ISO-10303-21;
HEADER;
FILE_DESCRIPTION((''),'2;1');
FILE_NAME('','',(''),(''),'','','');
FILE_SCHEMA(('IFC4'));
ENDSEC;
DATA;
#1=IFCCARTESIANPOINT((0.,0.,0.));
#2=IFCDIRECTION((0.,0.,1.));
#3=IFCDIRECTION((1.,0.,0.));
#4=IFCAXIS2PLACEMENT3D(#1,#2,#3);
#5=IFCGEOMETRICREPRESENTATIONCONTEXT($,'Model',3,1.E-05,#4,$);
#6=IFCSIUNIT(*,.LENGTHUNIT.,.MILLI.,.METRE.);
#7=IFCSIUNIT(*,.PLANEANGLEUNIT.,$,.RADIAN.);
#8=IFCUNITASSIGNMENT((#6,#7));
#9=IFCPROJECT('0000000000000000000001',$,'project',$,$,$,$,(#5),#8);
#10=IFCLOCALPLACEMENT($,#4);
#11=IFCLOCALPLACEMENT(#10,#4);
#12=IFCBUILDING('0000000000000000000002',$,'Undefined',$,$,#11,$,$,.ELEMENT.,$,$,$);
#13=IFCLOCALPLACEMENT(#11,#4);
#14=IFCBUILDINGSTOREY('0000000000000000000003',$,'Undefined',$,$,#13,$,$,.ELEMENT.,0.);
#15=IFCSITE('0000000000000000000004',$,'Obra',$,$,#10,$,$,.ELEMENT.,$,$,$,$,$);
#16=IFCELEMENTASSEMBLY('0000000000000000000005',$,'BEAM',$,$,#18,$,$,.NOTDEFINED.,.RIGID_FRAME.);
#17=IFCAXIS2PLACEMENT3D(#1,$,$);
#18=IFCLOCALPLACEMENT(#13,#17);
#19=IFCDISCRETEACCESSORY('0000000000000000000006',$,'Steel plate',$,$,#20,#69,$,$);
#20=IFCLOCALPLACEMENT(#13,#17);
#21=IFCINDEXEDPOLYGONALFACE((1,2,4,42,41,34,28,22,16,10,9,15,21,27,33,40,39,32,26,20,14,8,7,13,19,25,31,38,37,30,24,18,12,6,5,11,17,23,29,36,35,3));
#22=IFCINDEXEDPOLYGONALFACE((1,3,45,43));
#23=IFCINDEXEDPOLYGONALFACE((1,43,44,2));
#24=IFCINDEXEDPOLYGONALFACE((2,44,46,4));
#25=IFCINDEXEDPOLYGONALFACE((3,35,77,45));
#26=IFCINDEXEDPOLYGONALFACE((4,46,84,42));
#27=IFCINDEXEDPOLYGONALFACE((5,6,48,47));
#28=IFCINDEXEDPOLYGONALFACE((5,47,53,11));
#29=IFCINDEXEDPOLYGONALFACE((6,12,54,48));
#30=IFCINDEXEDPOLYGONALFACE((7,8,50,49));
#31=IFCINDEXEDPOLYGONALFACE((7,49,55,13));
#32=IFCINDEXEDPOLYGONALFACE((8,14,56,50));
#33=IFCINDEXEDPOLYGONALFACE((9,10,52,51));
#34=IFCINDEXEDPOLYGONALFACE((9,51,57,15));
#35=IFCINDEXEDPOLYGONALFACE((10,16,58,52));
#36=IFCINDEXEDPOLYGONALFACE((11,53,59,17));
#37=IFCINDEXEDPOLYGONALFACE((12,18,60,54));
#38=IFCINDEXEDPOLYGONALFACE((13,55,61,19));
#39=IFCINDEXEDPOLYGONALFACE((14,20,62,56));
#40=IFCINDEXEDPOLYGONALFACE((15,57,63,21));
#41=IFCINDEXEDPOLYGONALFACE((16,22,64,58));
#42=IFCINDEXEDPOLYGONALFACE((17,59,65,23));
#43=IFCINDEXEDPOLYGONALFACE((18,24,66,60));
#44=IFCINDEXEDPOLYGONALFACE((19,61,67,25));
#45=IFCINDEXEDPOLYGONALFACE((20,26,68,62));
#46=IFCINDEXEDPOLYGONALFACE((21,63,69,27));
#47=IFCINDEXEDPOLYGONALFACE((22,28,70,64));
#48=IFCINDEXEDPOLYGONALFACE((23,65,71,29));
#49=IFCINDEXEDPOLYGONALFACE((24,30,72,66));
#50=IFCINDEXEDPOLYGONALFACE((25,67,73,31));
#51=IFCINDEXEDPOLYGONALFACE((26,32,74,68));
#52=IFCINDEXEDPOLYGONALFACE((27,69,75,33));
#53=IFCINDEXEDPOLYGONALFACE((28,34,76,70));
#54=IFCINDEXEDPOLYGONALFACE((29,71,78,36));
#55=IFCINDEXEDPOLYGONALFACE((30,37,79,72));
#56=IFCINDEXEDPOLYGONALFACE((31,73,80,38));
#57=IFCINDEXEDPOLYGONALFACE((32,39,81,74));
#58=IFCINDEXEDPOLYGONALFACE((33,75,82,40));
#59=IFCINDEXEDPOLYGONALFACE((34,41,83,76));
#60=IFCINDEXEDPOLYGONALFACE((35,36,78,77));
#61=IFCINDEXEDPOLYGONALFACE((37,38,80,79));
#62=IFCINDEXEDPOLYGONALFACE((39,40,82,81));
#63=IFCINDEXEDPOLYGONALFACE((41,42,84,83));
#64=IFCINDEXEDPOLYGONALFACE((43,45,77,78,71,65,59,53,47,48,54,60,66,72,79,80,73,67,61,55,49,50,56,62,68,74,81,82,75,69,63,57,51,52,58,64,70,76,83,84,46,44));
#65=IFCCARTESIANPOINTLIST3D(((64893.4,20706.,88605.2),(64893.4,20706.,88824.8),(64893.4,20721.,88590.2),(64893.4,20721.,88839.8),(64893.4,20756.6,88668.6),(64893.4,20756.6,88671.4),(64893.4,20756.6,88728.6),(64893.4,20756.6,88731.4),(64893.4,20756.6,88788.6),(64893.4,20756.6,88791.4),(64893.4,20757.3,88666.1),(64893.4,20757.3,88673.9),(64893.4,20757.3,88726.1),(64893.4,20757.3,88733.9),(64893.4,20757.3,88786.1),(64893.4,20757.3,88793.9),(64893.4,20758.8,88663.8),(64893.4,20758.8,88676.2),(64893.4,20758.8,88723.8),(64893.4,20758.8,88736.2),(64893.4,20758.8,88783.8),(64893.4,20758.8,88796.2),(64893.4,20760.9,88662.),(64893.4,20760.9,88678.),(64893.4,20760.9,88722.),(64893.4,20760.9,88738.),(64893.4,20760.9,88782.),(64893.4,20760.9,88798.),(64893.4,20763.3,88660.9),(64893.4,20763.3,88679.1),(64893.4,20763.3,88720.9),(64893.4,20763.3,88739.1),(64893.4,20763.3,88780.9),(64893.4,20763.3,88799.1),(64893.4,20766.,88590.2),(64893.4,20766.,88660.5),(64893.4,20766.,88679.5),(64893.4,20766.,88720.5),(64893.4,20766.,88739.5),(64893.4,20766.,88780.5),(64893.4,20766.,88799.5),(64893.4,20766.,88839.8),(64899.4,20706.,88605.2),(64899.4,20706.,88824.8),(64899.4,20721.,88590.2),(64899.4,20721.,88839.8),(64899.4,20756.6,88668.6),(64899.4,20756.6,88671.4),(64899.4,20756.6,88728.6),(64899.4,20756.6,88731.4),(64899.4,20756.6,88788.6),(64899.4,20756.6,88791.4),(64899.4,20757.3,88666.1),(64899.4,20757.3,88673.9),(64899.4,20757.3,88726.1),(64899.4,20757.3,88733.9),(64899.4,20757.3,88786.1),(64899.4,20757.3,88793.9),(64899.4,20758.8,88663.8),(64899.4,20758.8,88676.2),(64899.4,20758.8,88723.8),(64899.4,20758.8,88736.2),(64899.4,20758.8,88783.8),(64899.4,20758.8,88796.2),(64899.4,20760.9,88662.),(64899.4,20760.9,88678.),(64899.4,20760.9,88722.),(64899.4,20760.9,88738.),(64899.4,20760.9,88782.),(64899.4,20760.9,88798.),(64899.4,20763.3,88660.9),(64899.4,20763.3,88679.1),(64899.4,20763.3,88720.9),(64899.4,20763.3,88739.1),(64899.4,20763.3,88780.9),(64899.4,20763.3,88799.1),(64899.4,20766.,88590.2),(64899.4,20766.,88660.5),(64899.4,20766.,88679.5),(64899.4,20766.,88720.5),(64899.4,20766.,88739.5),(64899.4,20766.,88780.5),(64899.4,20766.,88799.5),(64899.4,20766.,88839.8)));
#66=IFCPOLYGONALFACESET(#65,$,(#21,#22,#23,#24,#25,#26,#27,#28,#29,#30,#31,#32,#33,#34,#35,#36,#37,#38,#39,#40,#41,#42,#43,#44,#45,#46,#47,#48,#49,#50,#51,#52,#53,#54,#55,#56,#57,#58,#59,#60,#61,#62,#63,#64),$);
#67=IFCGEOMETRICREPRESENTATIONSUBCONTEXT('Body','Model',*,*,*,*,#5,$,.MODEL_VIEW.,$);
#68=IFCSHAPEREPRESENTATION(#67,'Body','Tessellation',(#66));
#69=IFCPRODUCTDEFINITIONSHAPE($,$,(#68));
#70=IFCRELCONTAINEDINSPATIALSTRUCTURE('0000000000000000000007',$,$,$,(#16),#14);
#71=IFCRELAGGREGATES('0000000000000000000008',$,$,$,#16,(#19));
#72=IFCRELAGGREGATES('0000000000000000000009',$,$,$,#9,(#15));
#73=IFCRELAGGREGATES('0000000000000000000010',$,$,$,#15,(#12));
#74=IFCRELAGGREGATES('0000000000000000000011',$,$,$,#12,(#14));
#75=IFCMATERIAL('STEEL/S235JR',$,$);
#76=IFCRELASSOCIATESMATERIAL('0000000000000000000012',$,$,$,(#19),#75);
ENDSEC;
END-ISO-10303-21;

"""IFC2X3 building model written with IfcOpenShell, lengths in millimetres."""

from ifc_helpers import new_model, si_unit, frame, origin_with_axes, origin_2d_with_axis, place, context, subcontext, project, spatial, polyline, circle, outline, extrude, source, transform, mapped, material, element, aggregate, save


model = new_model("IFC2X3")

# Units and contexts
model_context = context("Model", 3, precision=1e-05, world=origin_with_axes())
body_context = subcontext(model_context, "Body", "Model", "MODEL_VIEW")
ifc_project = project(units=[si_unit("LENGTHUNIT", "METRE", prefix="MILLI"), si_unit("PLANEANGLEUNIT", "RADIAN")], contexts=[model_context])

# Site, building, storey
site_placement = place(None, origin_with_axes())
site = spatial("IfcSite", under=ifc_project, at=site_placement, Name="Obra", CompositionType="ELEMENT")
building_placement = place(site_placement, origin_with_axes())
building = spatial("IfcBuilding", under=site, at=building_placement, Name="Undefined", CompositionType="ELEMENT")
storey_placement = place(building_placement, origin_with_axes())
storey = spatial("IfcBuildingStorey", under=building, at=storey_placement, Name="Undefined", CompositionType="ELEMENT", Elevation=0.0)

# Shared definitions
ifc_material = material(Name="STEEL/S235JR")

# Element assembly, discrete accessory, opening
assembly_1_placement = place(storey_placement, origin_with_axes())
assembly_1 = element("IfcElementAssembly", 1, at=assembly_1_placement, inside=storey, Name="BEAM", AssemblyPlace="NOTDEFINED", PredefinedType="RIGID_FRAME")
shared_shape_1 = source(origin_with_axes(), body_context, "Body", "SweptSolid", [
    extrude(circle(Radius=9.5, at=origin_2d_with_axis()), frame((0.0, -9.2, 0.0), z_axis=(0.0, 1.0, 0.0), x_axis=(1.0, 0.0, 0.0)), (0.0, 0.0, 1.0), 6.2),
])
discrete_accessory_1_placement = place(assembly_1_placement, frame((64896.4, 20766.0, 88590.2), z_axis=(-1.0, -0.000002, 0.0), x_axis=(0.000002, -1.0, 0.0)))
discrete_accessory_1 = element("IfcDiscreteAccessory", 2, at=discrete_accessory_1_placement, material=ifc_material, Name="Steel plate", context=body_context, shape_type="SweptSolid", body=[
    extrude(outline(polyline([(0.0, 0.0), (45.0, 0.0), (60.0, 15.0), (60.0, 234.6), (45.0, 249.6), (0.0, 249.6), (0.0, 0.0)])), frame((0.0, 0.0, -3.0), z_axis=(0.0, 0.0, 1.0), x_axis=(1.0, 0.0, 0.0)), (0.0, 0.0, 1.0), 6.0),
])
opening_1_placement = place(assembly_1_placement, frame((64890.3, 20716.0, 88850.0), z_axis=(-0.000002, 1.0, 0.0), x_axis=(0.0, 0.0, -1.0)))
element("IfcOpeningElement", 3, at=opening_1_placement, cuts=discrete_accessory_1, ObjectType="Opening", context=body_context, shape_type="MappedRepresentation", body=[
    mapped(shared_shape_1, transform((60.0, 0.0, 50.0))),
    mapped(shared_shape_1, transform((120.0, 0.0, 50.0))),
    mapped(shared_shape_1, transform((180.0, 0.0, 50.0))),
])
aggregate(assembly_1, [discrete_accessory_1])

save(model, "model.ifc")
